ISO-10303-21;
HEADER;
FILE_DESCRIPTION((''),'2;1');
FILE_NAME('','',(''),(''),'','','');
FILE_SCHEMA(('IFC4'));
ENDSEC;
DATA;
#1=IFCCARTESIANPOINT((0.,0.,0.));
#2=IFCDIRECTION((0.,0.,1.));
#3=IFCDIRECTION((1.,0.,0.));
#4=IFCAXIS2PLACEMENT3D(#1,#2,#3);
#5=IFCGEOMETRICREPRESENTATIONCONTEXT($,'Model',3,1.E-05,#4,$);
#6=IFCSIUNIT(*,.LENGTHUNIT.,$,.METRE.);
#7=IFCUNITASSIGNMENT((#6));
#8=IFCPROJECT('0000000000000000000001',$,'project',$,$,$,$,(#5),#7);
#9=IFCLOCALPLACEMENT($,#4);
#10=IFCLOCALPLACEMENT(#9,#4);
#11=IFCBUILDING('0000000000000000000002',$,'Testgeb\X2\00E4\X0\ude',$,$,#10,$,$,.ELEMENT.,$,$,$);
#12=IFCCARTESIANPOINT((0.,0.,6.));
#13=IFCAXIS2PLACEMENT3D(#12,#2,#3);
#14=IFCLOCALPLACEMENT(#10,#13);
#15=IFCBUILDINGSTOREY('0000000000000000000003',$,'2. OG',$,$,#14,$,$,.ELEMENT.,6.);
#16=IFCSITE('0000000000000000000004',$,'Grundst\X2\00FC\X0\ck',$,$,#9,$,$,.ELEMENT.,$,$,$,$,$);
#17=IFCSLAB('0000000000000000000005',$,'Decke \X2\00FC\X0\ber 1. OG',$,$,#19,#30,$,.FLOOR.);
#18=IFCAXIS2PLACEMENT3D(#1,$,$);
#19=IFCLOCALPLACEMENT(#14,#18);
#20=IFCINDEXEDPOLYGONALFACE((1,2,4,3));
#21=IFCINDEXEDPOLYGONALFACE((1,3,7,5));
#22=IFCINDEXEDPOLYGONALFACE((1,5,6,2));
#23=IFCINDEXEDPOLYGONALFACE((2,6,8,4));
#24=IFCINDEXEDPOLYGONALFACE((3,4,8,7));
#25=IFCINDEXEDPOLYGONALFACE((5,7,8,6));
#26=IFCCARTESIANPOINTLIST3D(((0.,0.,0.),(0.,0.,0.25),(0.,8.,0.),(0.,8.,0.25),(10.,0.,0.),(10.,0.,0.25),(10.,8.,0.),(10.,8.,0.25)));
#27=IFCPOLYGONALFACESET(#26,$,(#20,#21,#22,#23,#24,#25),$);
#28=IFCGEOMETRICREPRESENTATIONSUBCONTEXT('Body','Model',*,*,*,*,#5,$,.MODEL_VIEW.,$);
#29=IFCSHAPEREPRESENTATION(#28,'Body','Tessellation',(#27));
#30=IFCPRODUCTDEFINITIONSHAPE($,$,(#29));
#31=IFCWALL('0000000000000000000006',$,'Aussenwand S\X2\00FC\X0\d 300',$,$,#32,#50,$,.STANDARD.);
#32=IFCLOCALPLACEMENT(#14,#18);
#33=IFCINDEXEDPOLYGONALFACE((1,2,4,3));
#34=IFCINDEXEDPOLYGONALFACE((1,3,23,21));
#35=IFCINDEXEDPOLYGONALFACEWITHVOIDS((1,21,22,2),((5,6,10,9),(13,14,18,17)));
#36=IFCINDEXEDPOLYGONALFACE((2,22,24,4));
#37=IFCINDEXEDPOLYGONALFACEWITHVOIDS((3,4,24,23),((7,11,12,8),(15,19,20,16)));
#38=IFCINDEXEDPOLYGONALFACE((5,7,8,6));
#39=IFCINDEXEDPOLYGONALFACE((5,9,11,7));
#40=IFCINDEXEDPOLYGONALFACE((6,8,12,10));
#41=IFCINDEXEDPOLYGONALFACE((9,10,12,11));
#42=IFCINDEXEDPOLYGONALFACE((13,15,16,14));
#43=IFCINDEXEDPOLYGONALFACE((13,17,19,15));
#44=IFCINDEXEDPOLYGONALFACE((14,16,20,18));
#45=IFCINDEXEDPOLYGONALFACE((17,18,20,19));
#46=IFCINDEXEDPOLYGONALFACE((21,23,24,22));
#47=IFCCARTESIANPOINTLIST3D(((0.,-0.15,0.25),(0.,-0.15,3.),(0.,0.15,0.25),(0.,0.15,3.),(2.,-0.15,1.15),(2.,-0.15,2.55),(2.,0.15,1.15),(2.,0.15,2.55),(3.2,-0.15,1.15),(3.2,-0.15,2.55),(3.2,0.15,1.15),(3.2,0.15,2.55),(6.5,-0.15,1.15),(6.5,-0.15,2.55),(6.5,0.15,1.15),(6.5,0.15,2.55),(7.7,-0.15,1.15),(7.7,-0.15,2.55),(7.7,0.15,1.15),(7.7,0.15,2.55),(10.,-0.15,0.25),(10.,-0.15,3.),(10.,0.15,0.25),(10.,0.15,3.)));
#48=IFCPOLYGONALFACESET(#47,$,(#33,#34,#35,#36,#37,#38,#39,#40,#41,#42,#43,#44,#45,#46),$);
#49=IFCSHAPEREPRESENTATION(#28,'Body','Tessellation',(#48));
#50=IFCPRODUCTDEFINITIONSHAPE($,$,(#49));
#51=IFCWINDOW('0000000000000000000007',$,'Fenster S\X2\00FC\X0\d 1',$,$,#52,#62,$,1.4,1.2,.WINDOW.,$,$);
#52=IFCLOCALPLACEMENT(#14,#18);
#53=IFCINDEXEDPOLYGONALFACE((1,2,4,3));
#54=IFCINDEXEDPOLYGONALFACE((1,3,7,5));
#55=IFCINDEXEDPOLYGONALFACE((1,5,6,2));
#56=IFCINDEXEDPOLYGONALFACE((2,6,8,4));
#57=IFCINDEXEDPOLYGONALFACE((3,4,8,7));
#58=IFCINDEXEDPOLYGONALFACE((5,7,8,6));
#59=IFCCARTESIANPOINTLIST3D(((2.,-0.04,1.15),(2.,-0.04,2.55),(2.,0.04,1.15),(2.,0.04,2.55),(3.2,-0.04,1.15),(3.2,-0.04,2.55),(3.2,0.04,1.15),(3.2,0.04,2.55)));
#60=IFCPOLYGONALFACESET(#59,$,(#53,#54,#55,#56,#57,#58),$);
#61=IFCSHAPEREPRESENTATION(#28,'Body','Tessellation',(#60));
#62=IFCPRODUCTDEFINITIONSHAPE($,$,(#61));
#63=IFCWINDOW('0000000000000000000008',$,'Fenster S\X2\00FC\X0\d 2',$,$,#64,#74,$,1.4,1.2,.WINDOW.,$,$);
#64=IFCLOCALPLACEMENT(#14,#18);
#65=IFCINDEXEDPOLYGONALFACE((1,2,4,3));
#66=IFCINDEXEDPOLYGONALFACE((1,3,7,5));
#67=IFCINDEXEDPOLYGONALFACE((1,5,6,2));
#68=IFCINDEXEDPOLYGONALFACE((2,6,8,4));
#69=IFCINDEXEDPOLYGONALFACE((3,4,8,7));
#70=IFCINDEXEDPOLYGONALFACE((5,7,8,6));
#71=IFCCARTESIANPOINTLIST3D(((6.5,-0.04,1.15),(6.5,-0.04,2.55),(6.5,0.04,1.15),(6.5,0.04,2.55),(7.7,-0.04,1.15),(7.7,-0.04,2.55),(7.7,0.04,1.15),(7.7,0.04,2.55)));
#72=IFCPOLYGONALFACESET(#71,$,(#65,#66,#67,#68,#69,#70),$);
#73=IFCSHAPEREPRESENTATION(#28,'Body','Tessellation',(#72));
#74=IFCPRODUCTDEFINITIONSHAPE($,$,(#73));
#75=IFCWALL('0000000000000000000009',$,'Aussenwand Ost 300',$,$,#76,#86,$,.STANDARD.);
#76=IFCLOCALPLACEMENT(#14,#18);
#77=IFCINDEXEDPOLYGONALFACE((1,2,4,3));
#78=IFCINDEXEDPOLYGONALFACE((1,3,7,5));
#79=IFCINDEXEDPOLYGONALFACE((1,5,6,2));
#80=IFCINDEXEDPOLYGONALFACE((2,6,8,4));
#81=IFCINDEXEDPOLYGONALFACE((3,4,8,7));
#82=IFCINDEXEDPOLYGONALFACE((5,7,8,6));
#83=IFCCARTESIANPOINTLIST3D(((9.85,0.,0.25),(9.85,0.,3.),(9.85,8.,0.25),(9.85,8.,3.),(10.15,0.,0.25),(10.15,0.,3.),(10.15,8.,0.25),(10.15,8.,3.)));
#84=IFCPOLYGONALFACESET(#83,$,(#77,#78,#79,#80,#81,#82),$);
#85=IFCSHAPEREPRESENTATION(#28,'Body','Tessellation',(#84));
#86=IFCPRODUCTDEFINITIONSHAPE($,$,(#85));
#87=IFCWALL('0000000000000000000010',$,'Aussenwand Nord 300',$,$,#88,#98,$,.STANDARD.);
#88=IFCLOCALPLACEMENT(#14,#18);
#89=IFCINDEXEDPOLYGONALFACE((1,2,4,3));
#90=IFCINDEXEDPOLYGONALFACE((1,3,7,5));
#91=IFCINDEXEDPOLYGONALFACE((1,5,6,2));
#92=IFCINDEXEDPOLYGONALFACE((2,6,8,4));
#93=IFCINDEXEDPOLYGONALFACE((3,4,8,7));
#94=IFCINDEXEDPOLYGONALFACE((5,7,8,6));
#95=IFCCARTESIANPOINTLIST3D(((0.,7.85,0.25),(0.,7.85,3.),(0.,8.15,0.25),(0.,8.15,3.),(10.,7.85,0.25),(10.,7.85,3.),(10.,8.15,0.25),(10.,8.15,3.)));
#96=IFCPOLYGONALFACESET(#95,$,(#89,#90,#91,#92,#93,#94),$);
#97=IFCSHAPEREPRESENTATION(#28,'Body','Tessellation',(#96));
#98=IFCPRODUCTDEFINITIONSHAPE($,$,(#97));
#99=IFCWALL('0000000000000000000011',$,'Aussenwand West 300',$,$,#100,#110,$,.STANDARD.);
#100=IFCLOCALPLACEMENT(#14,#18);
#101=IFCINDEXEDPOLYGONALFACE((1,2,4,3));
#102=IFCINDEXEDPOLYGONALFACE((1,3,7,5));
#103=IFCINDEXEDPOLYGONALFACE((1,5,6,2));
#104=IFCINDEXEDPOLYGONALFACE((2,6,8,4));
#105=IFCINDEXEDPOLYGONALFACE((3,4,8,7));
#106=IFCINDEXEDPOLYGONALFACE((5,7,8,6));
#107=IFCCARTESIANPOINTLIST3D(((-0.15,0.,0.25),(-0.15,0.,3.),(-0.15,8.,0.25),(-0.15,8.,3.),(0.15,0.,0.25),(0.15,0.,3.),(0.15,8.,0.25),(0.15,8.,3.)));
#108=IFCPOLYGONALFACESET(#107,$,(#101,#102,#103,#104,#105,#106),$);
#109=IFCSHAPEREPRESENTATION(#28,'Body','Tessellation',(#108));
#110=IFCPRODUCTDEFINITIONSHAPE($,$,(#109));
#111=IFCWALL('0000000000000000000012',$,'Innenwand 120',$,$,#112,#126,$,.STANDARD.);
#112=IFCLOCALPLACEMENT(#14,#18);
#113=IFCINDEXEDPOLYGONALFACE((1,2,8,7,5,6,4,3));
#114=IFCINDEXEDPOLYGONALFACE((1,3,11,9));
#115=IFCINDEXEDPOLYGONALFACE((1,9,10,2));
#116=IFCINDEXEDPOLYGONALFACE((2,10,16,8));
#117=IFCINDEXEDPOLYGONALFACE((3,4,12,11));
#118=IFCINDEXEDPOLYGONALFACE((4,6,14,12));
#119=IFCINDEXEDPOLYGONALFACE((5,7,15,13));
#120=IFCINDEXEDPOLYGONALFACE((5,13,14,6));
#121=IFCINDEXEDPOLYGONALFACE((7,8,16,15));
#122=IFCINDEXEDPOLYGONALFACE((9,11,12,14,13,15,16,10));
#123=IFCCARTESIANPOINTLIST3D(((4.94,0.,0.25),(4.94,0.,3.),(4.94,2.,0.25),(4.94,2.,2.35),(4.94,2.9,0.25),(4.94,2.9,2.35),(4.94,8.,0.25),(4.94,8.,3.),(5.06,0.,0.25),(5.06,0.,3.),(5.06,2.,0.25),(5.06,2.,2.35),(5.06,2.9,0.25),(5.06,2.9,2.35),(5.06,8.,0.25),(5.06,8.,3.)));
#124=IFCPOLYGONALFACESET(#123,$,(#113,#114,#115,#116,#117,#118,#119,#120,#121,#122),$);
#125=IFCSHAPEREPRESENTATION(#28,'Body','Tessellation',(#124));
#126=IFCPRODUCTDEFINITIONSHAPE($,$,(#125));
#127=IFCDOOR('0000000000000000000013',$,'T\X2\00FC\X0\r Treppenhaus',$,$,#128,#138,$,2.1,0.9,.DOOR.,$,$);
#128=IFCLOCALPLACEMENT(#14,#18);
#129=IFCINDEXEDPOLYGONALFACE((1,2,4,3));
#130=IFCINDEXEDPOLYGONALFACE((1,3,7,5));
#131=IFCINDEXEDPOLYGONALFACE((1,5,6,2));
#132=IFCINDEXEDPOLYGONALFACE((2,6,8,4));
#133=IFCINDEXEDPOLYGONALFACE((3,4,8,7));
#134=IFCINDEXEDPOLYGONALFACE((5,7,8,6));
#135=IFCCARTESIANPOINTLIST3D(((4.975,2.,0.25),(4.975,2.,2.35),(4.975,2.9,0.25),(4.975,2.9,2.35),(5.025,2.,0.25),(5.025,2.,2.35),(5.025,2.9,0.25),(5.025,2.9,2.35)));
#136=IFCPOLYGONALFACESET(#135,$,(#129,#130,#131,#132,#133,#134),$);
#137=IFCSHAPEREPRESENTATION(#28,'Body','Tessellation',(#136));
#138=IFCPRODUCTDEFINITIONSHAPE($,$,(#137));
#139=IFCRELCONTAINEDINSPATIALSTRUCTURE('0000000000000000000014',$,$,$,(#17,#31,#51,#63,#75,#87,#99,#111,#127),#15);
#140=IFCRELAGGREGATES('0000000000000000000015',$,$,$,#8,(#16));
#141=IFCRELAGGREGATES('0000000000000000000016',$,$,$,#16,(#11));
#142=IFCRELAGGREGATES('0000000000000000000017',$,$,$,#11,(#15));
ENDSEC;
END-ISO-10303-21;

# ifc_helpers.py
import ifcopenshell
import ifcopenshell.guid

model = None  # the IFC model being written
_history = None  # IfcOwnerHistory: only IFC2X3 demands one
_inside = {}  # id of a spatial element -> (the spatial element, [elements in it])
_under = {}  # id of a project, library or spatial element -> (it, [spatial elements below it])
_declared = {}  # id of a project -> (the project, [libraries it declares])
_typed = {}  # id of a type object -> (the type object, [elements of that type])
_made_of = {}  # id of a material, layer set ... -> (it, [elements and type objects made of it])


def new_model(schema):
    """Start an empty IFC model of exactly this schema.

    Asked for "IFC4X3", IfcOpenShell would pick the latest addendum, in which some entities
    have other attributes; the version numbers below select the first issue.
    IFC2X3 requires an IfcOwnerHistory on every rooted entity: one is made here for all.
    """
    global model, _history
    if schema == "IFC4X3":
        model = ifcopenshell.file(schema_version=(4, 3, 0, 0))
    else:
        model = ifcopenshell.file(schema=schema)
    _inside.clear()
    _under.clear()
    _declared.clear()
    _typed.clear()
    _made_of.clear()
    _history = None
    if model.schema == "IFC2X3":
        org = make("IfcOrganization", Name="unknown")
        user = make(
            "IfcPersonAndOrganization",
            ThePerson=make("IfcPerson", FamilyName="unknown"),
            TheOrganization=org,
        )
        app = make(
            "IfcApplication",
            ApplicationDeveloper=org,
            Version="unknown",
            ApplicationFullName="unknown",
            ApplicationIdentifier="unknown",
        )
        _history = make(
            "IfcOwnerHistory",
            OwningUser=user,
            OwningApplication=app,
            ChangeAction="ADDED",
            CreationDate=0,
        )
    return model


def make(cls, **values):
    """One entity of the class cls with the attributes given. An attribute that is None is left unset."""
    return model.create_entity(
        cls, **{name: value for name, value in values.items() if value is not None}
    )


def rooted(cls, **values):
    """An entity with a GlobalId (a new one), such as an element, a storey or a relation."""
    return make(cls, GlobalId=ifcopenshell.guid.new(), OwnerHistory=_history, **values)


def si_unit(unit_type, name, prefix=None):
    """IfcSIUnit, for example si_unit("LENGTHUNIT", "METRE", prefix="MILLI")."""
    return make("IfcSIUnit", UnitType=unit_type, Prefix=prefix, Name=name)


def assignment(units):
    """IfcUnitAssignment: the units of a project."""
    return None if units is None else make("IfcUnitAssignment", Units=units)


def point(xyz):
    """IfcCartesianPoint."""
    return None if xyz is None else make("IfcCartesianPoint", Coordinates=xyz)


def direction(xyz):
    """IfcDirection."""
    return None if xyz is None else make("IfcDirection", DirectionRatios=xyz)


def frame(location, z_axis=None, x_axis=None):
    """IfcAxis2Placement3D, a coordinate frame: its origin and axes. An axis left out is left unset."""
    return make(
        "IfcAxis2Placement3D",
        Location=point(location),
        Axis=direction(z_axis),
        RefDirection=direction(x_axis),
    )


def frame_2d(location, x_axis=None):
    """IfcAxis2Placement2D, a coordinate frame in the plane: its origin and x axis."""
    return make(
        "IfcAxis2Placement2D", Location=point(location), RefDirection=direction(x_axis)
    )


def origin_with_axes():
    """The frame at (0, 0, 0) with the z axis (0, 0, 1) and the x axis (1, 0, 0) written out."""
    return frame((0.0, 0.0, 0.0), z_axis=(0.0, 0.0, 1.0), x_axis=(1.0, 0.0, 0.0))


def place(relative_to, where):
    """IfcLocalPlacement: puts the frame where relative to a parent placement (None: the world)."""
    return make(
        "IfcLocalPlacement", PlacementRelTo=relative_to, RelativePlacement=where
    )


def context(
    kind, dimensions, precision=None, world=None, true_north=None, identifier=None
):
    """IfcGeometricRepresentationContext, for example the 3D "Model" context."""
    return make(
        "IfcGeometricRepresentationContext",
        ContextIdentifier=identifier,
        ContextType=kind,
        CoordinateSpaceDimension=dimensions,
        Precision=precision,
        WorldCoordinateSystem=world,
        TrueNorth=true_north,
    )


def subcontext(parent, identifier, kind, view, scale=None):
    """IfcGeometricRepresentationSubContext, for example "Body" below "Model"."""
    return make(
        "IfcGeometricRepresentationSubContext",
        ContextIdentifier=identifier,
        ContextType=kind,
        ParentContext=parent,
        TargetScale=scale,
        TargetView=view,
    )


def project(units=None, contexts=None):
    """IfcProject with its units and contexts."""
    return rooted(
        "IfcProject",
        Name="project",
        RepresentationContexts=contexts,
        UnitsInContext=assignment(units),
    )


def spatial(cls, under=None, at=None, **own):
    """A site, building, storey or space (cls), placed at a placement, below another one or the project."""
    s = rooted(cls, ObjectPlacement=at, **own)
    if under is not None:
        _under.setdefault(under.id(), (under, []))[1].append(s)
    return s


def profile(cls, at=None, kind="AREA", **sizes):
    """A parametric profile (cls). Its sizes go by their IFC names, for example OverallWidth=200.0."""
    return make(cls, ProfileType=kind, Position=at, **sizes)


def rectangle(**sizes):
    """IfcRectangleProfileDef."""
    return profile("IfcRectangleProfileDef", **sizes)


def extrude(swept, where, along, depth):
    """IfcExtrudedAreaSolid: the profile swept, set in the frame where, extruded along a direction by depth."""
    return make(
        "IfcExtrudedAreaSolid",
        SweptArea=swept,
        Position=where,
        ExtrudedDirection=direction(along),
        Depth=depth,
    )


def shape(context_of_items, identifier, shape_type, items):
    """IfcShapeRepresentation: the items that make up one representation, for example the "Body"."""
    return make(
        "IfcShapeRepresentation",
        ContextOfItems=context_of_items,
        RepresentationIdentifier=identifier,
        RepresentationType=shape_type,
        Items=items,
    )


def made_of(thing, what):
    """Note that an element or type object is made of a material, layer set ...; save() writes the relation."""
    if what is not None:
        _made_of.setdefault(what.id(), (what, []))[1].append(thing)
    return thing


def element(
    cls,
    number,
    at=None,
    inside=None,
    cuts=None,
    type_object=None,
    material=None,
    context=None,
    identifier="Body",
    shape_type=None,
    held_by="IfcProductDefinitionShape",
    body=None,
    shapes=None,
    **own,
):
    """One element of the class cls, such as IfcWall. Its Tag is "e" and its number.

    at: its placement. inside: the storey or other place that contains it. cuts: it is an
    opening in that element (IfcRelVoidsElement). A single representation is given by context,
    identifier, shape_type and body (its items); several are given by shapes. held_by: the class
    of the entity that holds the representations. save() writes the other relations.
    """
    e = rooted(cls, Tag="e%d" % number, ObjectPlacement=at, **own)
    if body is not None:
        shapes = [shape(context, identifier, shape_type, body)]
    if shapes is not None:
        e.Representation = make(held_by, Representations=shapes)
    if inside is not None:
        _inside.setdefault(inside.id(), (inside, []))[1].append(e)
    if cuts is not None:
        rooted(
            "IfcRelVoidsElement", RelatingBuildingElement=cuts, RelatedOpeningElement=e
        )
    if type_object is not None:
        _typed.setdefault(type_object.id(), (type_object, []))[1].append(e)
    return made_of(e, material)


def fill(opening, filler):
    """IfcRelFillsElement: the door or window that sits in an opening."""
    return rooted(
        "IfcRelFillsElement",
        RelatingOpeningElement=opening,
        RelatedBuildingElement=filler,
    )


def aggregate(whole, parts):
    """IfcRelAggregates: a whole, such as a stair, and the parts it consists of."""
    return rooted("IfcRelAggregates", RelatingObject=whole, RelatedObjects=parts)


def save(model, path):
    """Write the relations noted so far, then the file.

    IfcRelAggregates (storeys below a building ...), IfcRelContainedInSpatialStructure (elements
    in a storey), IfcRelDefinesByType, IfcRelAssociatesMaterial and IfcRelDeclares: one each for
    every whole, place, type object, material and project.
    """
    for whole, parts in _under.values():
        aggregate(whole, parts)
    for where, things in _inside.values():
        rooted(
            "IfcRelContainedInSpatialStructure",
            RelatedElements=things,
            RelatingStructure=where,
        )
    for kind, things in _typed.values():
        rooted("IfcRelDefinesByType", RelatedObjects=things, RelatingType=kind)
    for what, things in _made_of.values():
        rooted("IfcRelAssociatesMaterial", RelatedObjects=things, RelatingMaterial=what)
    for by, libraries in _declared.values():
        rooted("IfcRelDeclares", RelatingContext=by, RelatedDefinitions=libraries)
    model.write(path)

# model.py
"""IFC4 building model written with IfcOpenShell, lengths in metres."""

from ifc_helpers import new_model, si_unit, frame, frame_2d, origin_with_axes, place, context, subcontext, project, spatial, rectangle, extrude, element, fill, save


model = new_model("IFC4")

# Units and contexts
model_context = context("Model", 3, precision=1e-05, world=origin_with_axes())
body_context = subcontext(model_context, "Body", "Model", "MODEL_VIEW")
ifc_project = project(units=[si_unit("LENGTHUNIT", "METRE")], contexts=[model_context])

# Site, building, storey
site_placement = place(None, origin_with_axes())
site = spatial("IfcSite", under=ifc_project, at=site_placement, Name="Grundstück", CompositionType="ELEMENT")
building_placement = place(site_placement, origin_with_axes())
building = spatial("IfcBuilding", under=site, at=building_placement, Name="Testgebäude", CompositionType="ELEMENT")
storey_placement = place(building_placement, frame((0.0, 0.0, 6.0), z_axis=(0.0, 0.0, 1.0), x_axis=(1.0, 0.0, 0.0)))
storey = spatial("IfcBuildingStorey", under=building, at=storey_placement, Name="2. OG", CompositionType="ELEMENT", Elevation=6.0)

# Slab
slab_placement = place(storey_placement, origin_with_axes())
element("IfcSlab", 1, at=slab_placement, inside=storey, Name="Decke über 1. OG", PredefinedType="FLOOR", context=body_context, shape_type="SweptSolid", body=[
    extrude(rectangle(XDim=10.0, YDim=8.0, at=frame_2d((5.0, 4.0))), origin_with_axes(), (0.0, 0.0, 1.0), 0.25),
])

# Wall, openings, windows
wall_1_placement = place(storey_placement, frame((0.0, 0.0, 0.25), z_axis=(0.0, 0.0, 1.0), x_axis=(1.0, 0.0, 0.0)))
wall_1 = element("IfcWall", 2, at=wall_1_placement, inside=storey, Name="Aussenwand Süd 300", PredefinedType="STANDARD", context=body_context, shape_type="SweptSolid", body=[
    extrude(rectangle(XDim=10.0, YDim=0.3, at=frame_2d((5.0, 0.0))), origin_with_axes(), (0.0, 0.0, 1.0), 2.75),
])
opening_1_placement = place(storey_placement, frame((2.0, 0.0, 1.15), z_axis=(0.0, 0.0, 1.0), x_axis=(1.0, 0.0, 0.0)))
opening_1 = element("IfcOpeningElement", 3, at=opening_1_placement, cuts=wall_1, PredefinedType="OPENING", context=body_context, shape_type="SweptSolid", body=[
    extrude(rectangle(XDim=1.2, YDim=0.5, at=frame_2d((0.6, 0.0))), origin_with_axes(), (0.0, 0.0, 1.0), 1.4),
])
opening_2_placement = place(storey_placement, frame((6.5, 0.0, 1.15), z_axis=(0.0, 0.0, 1.0), x_axis=(1.0, 0.0, 0.0)))
opening_2 = element("IfcOpeningElement", 4, at=opening_2_placement, cuts=wall_1, PredefinedType="OPENING", context=body_context, shape_type="SweptSolid", body=[
    extrude(rectangle(XDim=1.2, YDim=0.5, at=frame_2d((0.6, 0.0))), origin_with_axes(), (0.0, 0.0, 1.0), 1.4),
])
window_1_placement = place(storey_placement, frame((2.0, 0.0, 1.15), z_axis=(0.0, 0.0, 1.0), x_axis=(1.0, 0.0, 0.0)))
window_1 = element("IfcWindow", 5, at=window_1_placement, inside=storey, Name="Fenster Süd 1", OverallHeight=1.4, OverallWidth=1.2, PredefinedType="WINDOW", context=body_context, shape_type="SweptSolid", body=[
    extrude(rectangle(XDim=1.2, YDim=0.08, at=frame_2d((0.6, 0.0))), origin_with_axes(), (0.0, 0.0, 1.0), 1.4),
])
fill(opening_1, window_1)
window_2_placement = place(storey_placement, frame((6.5, 0.0, 1.15), z_axis=(0.0, 0.0, 1.0), x_axis=(1.0, 0.0, 0.0)))
window_2 = element("IfcWindow", 6, at=window_2_placement, inside=storey, Name="Fenster Süd 2", OverallHeight=1.4, OverallWidth=1.2, PredefinedType="WINDOW", context=body_context, shape_type="SweptSolid", body=[
    extrude(rectangle(XDim=1.2, YDim=0.08, at=frame_2d((0.6, 0.0))), origin_with_axes(), (0.0, 0.0, 1.0), 1.4),
])
fill(opening_2, window_2)

# Walls
wall_2_placement = place(storey_placement, frame((10.0, 0.0, 0.25), z_axis=(0.0, 0.0, 1.0), x_axis=(0.0, 1.0, 0.0)))
element("IfcWall", 7, at=wall_2_placement, inside=storey, Name="Aussenwand Ost 300", PredefinedType="STANDARD", context=body_context, shape_type="SweptSolid", body=[
    extrude(rectangle(XDim=8.0, YDim=0.3, at=frame_2d((4.0, 0.0))), origin_with_axes(), (0.0, 0.0, 1.0), 2.75),
])
wall_3_placement = place(storey_placement, frame((10.0, 8.0, 0.25), z_axis=(0.0, 0.0, 1.0), x_axis=(-1.0, 0.0, 0.0)))
element("IfcWall", 8, at=wall_3_placement, inside=storey, Name="Aussenwand Nord 300", PredefinedType="STANDARD", context=body_context, shape_type="SweptSolid", body=[
    extrude(rectangle(XDim=10.0, YDim=0.3, at=frame_2d((5.0, 0.0))), origin_with_axes(), (0.0, 0.0, 1.0), 2.75),
])
wall_4_placement = place(storey_placement, frame((0.0, 8.0, 0.25), z_axis=(0.0, 0.0, 1.0), x_axis=(0.0, -1.0, 0.0)))
element("IfcWall", 9, at=wall_4_placement, inside=storey, Name="Aussenwand West 300", PredefinedType="STANDARD", context=body_context, shape_type="SweptSolid", body=[
    extrude(rectangle(XDim=8.0, YDim=0.3, at=frame_2d((4.0, 0.0))), origin_with_axes(), (0.0, 0.0, 1.0), 2.75),
])

# Wall, opening, door
wall_5_placement = place(storey_placement, frame((5.0, 0.0, 0.25), z_axis=(0.0, 0.0, 1.0), x_axis=(0.0, 1.0, 0.0)))
wall_5 = element("IfcWall", 10, at=wall_5_placement, inside=storey, Name="Innenwand 120", PredefinedType="STANDARD", context=body_context, shape_type="SweptSolid", body=[
    extrude(rectangle(XDim=8.0, YDim=0.12, at=frame_2d((4.0, 0.0))), origin_with_axes(), (0.0, 0.0, 1.0), 2.75),
])
opening_3_placement = place(storey_placement, frame((5.0, 2.0, 0.25), z_axis=(0.0, 0.0, 1.0), x_axis=(0.0, 1.0, 0.0)))
opening_3 = element("IfcOpeningElement", 11, at=opening_3_placement, cuts=wall_5, PredefinedType="OPENING", context=body_context, shape_type="SweptSolid", body=[
    extrude(rectangle(XDim=0.9, YDim=0.4, at=frame_2d((0.45, 0.0))), origin_with_axes(), (0.0, 0.0, 1.0), 2.1),
])
door_placement = place(storey_placement, frame((5.0, 2.0, 0.25), z_axis=(0.0, 0.0, 1.0), x_axis=(0.0, 1.0, 0.0)))
door = element("IfcDoor", 12, at=door_placement, inside=storey, Name="Tür Treppenhaus", OverallHeight=2.1, OverallWidth=0.9, PredefinedType="DOOR", context=body_context, shape_type="SweptSolid", body=[
    extrude(rectangle(XDim=0.9, YDim=0.05, at=frame_2d((0.45, 0.0))), origin_with_axes(), (0.0, 0.0, 1.0), 2.1),
])
fill(opening_3, door)

save(model, "model.ifc")
